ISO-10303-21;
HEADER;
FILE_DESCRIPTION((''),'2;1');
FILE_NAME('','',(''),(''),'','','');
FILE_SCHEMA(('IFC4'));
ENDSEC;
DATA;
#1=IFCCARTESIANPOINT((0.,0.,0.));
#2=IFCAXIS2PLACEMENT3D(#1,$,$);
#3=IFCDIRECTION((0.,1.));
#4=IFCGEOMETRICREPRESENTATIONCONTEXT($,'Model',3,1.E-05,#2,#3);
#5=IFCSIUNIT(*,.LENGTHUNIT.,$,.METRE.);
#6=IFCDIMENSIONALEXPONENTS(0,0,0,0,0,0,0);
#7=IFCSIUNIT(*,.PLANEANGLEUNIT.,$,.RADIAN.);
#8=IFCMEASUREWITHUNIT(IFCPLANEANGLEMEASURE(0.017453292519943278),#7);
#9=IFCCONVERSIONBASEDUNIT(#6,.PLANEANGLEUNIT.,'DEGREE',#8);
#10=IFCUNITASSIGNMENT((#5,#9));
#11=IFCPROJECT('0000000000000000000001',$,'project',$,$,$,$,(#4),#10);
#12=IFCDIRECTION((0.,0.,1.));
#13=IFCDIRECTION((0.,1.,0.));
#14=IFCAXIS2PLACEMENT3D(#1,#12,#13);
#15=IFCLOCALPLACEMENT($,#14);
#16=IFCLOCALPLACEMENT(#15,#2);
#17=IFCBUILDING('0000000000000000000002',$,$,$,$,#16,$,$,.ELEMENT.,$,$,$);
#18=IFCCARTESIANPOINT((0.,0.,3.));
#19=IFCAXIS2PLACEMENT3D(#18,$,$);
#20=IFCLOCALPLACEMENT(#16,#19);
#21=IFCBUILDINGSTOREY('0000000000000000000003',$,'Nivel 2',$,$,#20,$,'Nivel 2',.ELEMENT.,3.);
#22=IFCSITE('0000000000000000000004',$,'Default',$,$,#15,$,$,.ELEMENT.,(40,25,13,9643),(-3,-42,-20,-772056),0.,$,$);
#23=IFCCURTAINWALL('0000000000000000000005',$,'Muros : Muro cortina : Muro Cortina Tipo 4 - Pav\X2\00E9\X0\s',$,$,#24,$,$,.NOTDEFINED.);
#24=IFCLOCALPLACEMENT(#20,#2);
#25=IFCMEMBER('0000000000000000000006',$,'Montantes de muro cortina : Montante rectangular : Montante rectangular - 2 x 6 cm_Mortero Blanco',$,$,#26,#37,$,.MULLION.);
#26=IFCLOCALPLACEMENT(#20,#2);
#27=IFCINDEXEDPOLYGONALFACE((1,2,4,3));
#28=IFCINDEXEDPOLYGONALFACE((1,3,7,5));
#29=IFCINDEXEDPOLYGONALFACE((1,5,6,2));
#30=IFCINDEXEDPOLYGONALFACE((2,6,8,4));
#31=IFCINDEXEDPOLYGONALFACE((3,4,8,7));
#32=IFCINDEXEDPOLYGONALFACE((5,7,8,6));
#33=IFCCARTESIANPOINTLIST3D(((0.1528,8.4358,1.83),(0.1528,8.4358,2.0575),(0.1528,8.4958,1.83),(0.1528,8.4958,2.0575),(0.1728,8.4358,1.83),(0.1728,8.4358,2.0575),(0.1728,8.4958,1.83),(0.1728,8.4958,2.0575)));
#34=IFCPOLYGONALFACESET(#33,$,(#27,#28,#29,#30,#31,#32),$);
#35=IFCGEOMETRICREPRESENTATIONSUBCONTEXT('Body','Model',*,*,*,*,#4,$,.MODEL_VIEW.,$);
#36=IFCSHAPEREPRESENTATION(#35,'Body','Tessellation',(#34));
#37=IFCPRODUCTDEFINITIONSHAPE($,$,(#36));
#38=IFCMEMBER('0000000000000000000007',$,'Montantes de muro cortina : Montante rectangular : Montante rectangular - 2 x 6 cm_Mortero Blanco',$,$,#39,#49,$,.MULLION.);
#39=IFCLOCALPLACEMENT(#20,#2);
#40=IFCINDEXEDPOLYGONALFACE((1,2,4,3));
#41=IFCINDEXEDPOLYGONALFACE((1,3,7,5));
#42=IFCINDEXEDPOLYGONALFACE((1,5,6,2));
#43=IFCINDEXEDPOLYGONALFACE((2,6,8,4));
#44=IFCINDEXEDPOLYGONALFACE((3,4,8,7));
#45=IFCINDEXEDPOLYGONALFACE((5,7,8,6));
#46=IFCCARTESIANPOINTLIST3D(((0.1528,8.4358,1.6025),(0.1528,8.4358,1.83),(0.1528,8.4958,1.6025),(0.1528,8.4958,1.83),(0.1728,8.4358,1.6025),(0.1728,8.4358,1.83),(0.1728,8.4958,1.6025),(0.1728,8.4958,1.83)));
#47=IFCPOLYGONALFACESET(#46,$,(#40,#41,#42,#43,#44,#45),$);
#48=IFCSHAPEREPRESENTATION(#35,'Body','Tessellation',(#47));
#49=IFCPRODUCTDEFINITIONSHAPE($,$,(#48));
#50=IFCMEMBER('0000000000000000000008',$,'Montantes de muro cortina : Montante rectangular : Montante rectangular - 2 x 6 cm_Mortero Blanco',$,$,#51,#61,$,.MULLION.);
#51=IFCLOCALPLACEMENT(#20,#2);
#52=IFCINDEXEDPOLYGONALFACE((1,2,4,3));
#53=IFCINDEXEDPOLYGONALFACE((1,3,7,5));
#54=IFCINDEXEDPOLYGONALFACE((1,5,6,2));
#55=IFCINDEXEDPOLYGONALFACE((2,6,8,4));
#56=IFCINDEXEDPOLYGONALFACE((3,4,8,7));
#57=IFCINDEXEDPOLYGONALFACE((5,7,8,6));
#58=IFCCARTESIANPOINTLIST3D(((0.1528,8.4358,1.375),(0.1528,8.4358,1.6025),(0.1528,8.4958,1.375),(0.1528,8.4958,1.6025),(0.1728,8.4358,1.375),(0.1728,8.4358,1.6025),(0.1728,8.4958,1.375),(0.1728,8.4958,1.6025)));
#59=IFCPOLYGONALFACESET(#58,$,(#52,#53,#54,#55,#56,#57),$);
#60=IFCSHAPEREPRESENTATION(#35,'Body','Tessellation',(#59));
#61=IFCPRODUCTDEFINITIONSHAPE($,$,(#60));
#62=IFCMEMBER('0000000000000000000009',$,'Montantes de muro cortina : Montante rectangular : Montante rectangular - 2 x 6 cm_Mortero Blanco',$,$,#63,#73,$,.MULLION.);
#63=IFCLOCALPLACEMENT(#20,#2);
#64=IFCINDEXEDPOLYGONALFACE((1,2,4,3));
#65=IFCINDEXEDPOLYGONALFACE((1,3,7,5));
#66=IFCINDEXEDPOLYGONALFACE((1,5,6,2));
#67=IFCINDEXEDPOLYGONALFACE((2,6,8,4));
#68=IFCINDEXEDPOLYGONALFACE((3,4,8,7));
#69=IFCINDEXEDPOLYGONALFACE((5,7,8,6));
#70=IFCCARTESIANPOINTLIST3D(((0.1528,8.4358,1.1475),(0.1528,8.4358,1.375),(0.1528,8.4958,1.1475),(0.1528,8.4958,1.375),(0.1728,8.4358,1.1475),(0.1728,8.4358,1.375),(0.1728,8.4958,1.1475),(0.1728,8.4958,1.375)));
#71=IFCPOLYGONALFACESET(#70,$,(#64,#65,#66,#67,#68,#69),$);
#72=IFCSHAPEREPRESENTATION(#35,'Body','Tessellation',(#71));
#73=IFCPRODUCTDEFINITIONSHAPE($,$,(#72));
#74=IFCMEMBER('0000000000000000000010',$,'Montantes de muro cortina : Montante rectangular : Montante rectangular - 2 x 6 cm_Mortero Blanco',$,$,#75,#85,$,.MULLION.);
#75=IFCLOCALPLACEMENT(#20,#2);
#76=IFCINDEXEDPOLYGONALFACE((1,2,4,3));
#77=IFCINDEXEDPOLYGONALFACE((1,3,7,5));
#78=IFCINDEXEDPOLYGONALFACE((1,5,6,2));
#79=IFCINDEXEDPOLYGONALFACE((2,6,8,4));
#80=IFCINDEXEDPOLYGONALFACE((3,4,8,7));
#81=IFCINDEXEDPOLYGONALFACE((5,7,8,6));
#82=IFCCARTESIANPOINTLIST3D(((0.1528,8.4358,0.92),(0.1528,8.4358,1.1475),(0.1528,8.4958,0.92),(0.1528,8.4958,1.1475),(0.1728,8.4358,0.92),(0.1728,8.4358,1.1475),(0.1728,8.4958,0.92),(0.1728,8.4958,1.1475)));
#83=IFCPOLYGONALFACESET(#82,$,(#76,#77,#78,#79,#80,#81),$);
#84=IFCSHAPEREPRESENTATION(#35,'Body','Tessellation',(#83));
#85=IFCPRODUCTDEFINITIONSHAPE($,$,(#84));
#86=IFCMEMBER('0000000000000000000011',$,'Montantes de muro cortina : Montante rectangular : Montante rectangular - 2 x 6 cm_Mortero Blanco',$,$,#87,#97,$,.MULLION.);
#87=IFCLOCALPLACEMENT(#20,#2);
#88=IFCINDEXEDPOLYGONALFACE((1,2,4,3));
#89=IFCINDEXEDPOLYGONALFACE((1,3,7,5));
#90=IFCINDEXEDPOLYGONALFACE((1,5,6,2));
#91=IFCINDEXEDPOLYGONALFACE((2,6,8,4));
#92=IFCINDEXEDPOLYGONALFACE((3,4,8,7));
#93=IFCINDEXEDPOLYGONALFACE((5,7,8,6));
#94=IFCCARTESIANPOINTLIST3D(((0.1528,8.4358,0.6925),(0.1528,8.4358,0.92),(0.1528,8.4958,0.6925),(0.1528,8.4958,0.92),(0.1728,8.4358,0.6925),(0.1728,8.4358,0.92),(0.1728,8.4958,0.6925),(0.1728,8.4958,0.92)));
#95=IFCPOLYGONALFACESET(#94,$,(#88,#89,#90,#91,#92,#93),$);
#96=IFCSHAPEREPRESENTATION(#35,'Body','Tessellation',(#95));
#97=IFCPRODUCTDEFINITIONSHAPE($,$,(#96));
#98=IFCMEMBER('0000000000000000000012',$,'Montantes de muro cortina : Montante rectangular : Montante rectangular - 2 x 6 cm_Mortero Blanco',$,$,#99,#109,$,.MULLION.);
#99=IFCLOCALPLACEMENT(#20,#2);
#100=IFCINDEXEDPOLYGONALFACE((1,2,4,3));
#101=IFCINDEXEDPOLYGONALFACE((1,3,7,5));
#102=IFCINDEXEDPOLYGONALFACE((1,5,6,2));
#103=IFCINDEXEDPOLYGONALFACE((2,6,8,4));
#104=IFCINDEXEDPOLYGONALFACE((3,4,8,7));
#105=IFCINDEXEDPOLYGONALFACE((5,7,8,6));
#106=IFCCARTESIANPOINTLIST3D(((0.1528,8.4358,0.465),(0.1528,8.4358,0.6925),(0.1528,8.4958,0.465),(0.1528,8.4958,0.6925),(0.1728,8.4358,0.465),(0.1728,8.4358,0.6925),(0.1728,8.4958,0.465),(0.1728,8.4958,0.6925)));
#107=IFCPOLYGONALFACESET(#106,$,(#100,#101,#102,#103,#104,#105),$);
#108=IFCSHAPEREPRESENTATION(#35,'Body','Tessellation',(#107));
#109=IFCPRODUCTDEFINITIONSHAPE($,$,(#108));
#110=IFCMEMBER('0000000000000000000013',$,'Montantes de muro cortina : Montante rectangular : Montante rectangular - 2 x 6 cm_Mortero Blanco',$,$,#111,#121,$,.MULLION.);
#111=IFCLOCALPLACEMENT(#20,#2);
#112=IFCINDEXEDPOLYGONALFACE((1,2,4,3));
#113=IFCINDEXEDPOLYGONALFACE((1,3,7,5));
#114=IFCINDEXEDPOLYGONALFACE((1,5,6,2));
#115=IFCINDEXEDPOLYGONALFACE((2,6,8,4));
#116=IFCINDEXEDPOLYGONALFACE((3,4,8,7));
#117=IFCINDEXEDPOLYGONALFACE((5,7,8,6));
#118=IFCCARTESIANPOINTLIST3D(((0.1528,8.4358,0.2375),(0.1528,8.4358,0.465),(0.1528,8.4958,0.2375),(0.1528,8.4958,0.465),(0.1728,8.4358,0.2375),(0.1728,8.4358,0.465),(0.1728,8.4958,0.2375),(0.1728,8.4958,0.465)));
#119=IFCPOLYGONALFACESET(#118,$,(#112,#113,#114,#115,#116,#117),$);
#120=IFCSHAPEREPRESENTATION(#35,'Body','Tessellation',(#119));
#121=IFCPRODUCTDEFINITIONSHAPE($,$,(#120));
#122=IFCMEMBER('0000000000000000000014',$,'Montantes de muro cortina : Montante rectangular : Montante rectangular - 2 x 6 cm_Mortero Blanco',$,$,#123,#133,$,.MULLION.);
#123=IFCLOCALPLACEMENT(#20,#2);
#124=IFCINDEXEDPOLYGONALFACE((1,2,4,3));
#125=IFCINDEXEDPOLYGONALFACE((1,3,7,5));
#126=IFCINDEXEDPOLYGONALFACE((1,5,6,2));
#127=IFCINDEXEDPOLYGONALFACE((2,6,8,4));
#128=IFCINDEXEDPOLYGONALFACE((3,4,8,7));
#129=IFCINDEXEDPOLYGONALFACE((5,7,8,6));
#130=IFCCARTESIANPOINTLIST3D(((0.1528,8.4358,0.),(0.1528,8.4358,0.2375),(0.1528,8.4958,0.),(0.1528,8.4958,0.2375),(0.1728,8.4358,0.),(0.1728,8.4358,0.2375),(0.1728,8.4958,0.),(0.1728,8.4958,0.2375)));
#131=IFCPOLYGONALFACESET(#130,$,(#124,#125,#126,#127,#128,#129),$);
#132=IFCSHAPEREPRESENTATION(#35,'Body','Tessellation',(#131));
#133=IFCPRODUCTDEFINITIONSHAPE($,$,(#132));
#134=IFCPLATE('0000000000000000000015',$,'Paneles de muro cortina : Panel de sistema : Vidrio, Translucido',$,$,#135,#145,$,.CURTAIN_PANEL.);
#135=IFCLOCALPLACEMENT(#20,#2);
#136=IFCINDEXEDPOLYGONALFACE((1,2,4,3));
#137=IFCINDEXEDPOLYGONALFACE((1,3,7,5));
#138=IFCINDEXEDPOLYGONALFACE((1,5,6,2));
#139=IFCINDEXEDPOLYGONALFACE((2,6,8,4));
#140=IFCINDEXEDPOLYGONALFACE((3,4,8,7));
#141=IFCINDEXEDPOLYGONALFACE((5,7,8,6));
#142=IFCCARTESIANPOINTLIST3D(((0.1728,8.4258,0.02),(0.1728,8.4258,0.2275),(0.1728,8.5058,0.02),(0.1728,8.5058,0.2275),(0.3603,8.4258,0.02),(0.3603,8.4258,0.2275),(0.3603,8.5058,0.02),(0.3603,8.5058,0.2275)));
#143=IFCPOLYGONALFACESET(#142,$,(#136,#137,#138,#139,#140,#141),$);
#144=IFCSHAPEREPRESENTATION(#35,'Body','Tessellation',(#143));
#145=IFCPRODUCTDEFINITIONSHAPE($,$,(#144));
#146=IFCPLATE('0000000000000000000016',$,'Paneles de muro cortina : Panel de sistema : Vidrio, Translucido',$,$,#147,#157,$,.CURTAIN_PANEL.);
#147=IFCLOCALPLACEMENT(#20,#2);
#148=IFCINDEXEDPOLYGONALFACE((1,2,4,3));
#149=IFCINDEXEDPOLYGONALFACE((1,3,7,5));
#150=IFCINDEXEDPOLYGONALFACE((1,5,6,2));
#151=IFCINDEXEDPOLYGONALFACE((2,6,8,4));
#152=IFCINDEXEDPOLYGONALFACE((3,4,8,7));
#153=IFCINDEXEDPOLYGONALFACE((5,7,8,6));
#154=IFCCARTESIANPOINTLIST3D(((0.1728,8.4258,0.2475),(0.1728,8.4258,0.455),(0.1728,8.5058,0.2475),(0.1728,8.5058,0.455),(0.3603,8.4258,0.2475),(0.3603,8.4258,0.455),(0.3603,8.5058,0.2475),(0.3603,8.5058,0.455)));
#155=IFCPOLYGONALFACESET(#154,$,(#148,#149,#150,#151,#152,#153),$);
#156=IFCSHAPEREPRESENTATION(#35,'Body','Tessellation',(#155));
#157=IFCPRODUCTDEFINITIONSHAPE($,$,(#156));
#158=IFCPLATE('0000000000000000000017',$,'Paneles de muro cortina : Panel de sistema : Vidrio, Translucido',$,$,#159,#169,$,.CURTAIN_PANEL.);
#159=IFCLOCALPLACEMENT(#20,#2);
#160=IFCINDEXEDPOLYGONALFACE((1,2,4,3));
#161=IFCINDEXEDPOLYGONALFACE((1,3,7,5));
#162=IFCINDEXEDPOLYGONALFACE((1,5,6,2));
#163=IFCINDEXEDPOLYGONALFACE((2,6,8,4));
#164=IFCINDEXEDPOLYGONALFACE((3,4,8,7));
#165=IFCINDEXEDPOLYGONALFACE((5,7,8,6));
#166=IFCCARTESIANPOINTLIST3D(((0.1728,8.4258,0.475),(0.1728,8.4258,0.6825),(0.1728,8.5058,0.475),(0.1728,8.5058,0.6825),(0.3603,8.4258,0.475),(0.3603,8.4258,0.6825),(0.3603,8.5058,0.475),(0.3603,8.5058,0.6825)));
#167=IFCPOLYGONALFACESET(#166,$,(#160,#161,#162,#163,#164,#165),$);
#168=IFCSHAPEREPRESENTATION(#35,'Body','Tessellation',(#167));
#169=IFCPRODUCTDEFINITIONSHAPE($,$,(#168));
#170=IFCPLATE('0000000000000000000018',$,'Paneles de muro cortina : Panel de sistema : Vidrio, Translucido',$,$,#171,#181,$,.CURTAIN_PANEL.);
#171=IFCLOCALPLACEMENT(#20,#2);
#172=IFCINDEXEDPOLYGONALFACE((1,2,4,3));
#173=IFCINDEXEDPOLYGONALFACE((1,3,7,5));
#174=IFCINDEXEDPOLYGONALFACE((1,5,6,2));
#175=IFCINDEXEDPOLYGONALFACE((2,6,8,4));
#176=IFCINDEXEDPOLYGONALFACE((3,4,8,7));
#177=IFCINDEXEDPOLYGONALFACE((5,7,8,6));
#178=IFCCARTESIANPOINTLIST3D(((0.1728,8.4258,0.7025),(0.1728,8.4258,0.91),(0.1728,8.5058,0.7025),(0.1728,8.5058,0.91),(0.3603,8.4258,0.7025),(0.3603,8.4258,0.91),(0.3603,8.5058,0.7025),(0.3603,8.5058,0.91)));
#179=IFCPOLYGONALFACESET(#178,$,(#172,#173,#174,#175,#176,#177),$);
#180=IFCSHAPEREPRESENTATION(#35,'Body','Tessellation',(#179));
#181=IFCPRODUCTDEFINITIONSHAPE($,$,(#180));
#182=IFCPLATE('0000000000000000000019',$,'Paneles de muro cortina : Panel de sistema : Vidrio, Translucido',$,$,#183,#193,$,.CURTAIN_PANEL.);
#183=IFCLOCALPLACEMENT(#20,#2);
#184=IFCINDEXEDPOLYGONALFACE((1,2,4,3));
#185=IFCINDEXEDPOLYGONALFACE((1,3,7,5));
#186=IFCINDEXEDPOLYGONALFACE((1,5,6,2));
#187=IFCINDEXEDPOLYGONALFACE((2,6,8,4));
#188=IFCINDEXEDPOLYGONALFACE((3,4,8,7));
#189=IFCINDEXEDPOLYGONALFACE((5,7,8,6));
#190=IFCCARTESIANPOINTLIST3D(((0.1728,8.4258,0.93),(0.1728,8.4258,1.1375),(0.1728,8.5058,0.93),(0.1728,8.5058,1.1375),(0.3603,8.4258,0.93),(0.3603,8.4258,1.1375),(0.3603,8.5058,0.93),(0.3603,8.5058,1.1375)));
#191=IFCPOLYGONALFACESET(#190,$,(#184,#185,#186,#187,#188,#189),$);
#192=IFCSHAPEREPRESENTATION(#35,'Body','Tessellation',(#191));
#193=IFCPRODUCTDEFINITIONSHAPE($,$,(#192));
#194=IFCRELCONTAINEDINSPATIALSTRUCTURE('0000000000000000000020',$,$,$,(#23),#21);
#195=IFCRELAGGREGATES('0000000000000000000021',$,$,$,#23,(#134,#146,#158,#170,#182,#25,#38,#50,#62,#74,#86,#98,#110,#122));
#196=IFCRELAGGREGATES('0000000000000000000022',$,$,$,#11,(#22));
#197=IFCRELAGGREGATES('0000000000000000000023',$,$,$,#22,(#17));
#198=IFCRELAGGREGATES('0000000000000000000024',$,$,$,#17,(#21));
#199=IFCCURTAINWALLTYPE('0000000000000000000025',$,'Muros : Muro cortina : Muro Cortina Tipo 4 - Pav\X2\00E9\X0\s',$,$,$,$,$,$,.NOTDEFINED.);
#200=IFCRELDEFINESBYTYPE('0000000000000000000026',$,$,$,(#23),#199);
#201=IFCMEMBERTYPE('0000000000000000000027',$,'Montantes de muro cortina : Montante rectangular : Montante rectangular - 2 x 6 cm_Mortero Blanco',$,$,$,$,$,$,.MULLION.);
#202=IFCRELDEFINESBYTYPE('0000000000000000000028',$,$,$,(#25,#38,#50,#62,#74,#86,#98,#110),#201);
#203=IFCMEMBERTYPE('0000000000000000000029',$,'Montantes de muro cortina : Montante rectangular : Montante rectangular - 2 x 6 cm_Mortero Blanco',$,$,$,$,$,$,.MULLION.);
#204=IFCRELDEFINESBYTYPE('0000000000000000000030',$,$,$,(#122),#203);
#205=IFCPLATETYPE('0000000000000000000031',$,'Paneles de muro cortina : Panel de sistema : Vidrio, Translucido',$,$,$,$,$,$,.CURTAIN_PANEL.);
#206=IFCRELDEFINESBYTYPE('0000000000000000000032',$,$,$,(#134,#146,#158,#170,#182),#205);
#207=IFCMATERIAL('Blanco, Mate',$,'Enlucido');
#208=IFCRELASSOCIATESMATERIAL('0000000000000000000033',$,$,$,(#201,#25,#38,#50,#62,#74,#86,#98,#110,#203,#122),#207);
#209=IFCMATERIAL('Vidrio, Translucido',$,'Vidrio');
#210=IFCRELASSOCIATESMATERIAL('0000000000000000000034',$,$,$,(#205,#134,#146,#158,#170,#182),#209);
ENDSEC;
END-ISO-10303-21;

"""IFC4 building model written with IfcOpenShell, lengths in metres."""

from ifc_helpers import new_model, entity, si_unit, converted_unit, direction, frame, origin, place, context, subcontext, project, spatial, indexed_curve, outline, extrude, source, transform, mapped, material, type_object, type_shapes, element, aggregate, save


model = new_model("IFC4")

# Units and contexts
model_context = context("Model", 3, precision=1e-05, world=origin(), true_north=direction((0.0, 1.0)))
body_context = subcontext(model_context, "Body", "Model", "MODEL_VIEW")
ifc_project = project(units=[si_unit("LENGTHUNIT", "METRE"), converted_unit("PLANEANGLEUNIT", "DEGREE", entity("IfcPlaneAngleMeasure", 0.017453292519943278), si_unit("PLANEANGLEUNIT", "RADIAN"), dimensions=[0, 0, 0, 0, 0, 0, 0])], contexts=[model_context])

# Site, building, storey
site_placement = place(None, frame((0.0, 0.0, 0.0), z_axis=(0.0, 0.0, 1.0), x_axis=(0.0, 1.0, 0.0)))
site = spatial("IfcSite", under=ifc_project, at=site_placement, Name="Default", CompositionType="ELEMENT", RefLatitude=(40, 25, 13, 9643), RefLongitude=(-3, -42, -20, -772056), RefElevation=0.0)
building_placement = place(site_placement, origin())
building = spatial("IfcBuilding", under=site, at=building_placement, CompositionType="ELEMENT")
storey_placement = place(building_placement, frame((0.0, 0.0, 3.0)))
storey = spatial("IfcBuildingStorey", under=building, at=storey_placement, Name="Nivel 2", LongName="Nivel 2", CompositionType="ELEMENT", Elevation=3.0)

# Curtain wall, members, plates
curtain_wall_type = type_object("IfcCurtainWallType", Name="Muros : Muro cortina : Muro Cortina Tipo 4 - Pavés", PredefinedType="NOTDEFINED")
curtain_wall_placement = place(storey_placement, frame((0.0, 0.0, -3.0)))
curtain_wall = element("IfcCurtainWall", 1, at=curtain_wall_placement, inside=storey, type_object=curtain_wall_type, Name="Muros : Muro cortina : Muro Cortina Tipo 4 - Pavés", PredefinedType="NOTDEFINED")
ifc_material_1 = material(Name="Blanco, Mate", Category="Enlucido")
member_type_1 = type_object("IfcMemberType", Name="Montantes de muro cortina : Montante rectangular : Montante rectangular - 2 x 6 cm_Mortero Blanco", PredefinedType="MULLION", material=ifc_material_1)
shared_shape_1 = source(origin(), body_context, "Body", "SweptSolid", [
    extrude(outline(indexed_curve([(-0.01, -0.03), (0.01, -0.03), (0.01, 0.03), (-0.01, 0.03), (-0.01, -0.03)], self_intersect=False)), frame((-0.01, 0.0, -0.2275), z_axis=(0.0, 0.0, 1.0), x_axis=(-1.0, 0.0, 0.0)), (0.0, 0.0, 1.0), 0.2275),
])
type_shapes(member_type_1, [shared_shape_1])
member_1_placement = place(curtain_wall_placement, frame((0.1528, 8.4658, 4.83), z_axis=(0.0, 0.0, -1.0), x_axis=(-1.0, 0.0, 0.0)))
member_1 = element("IfcMember", 2, at=member_1_placement, type_object=member_type_1, material=ifc_material_1, Name="Montantes de muro cortina : Montante rectangular : Montante rectangular - 2 x 6 cm_Mortero Blanco", PredefinedType="MULLION", context=body_context, shape_type="MappedRepresentation", body=[
    mapped(shared_shape_1, transform((0.0, 0.0, 0.0), scale=1.0)),
])
member_2_placement = place(curtain_wall_placement, frame((0.1528, 8.4658, 4.6025), z_axis=(0.0, 0.0, -1.0), x_axis=(-1.0, 0.0, 0.0)))
member_2 = element("IfcMember", 3, at=member_2_placement, type_object=member_type_1, material=ifc_material_1, Name="Montantes de muro cortina : Montante rectangular : Montante rectangular - 2 x 6 cm_Mortero Blanco", PredefinedType="MULLION", context=body_context, shape_type="MappedRepresentation", body=[
    mapped(shared_shape_1, transform((0.0, 0.0, 0.0), scale=1.0)),
])
member_3_placement = place(curtain_wall_placement, frame((0.1528, 8.4658, 4.375), z_axis=(0.0, 0.0, -1.0), x_axis=(-1.0, 0.0, 0.0)))
member_3 = element("IfcMember", 4, at=member_3_placement, type_object=member_type_1, material=ifc_material_1, Name="Montantes de muro cortina : Montante rectangular : Montante rectangular - 2 x 6 cm_Mortero Blanco", PredefinedType="MULLION", context=body_context, shape_type="MappedRepresentation", body=[
    mapped(shared_shape_1, transform((0.0, 0.0, 0.0), scale=1.0)),
])
member_4_placement = place(curtain_wall_placement, frame((0.1528, 8.4658, 4.1475), z_axis=(0.0, 0.0, -1.0), x_axis=(-1.0, 0.0, 0.0)))
member_4 = element("IfcMember", 5, at=member_4_placement, type_object=member_type_1, material=ifc_material_1, Name="Montantes de muro cortina : Montante rectangular : Montante rectangular - 2 x 6 cm_Mortero Blanco", PredefinedType="MULLION", context=body_context, shape_type="MappedRepresentation", body=[
    mapped(shared_shape_1, transform((0.0, 0.0, 0.0), scale=1.0)),
])
member_5_placement = place(curtain_wall_placement, frame((0.1528, 8.4658, 3.92), z_axis=(0.0, 0.0, -1.0), x_axis=(-1.0, 0.0, 0.0)))
member_5 = element("IfcMember", 6, at=member_5_placement, type_object=member_type_1, material=ifc_material_1, Name="Montantes de muro cortina : Montante rectangular : Montante rectangular - 2 x 6 cm_Mortero Blanco", PredefinedType="MULLION", context=body_context, shape_type="MappedRepresentation", body=[
    mapped(shared_shape_1, transform((0.0, 0.0, 0.0), scale=1.0)),
])
member_6_placement = place(curtain_wall_placement, frame((0.1528, 8.4658, 3.6925), z_axis=(0.0, 0.0, -1.0), x_axis=(-1.0, 0.0, 0.0)))
member_6 = element("IfcMember", 7, at=member_6_placement, type_object=member_type_1, material=ifc_material_1, Name="Montantes de muro cortina : Montante rectangular : Montante rectangular - 2 x 6 cm_Mortero Blanco", PredefinedType="MULLION", context=body_context, shape_type="MappedRepresentation", body=[
    mapped(shared_shape_1, transform((0.0, 0.0, 0.0), scale=1.0)),
])
member_7_placement = place(curtain_wall_placement, frame((0.1528, 8.4658, 3.465), z_axis=(0.0, 0.0, -1.0), x_axis=(-1.0, 0.0, 0.0)))
member_7 = element("IfcMember", 8, at=member_7_placement, type_object=member_type_1, material=ifc_material_1, Name="Montantes de muro cortina : Montante rectangular : Montante rectangular - 2 x 6 cm_Mortero Blanco", PredefinedType="MULLION", context=body_context, shape_type="MappedRepresentation", body=[
    mapped(shared_shape_1, transform((0.0, 0.0, 0.0), scale=1.0)),
])
member_8_placement = place(curtain_wall_placement, frame((0.1528, 8.4658, 3.2375), z_axis=(0.0, 0.0, -1.0), x_axis=(-1.0, 0.0, 0.0)))
member_8 = element("IfcMember", 9, at=member_8_placement, type_object=member_type_1, material=ifc_material_1, Name="Montantes de muro cortina : Montante rectangular : Montante rectangular - 2 x 6 cm_Mortero Blanco", PredefinedType="MULLION", context=body_context, shape_type="MappedRepresentation", body=[
    mapped(shared_shape_1, transform((0.0, 0.0, 0.0), scale=1.0)),
])
member_type_2 = type_object("IfcMemberType", Name="Montantes de muro cortina : Montante rectangular : Montante rectangular - 2 x 6 cm_Mortero Blanco", PredefinedType="MULLION", material=ifc_material_1)
shared_shape_2 = source(origin(), body_context, "Body", "SweptSolid", [
    extrude(outline(indexed_curve([(-0.01, -0.03), (0.01, -0.03), (0.01, 0.03), (-0.01, 0.03), (-0.01, -0.03)], self_intersect=False)), frame((-0.01, 0.0, -0.2375), z_axis=(0.0, 0.0, 1.0), x_axis=(-1.0, 0.0, 0.0)), (0.0, 0.0, 1.0), 0.2375),
])
type_shapes(member_type_2, [shared_shape_2])
member_9_placement = place(curtain_wall_placement, frame((0.1528, 8.4658, 3.0), z_axis=(0.0, 0.0, -1.0), x_axis=(-1.0, 0.0, 0.0)))
member_9 = element("IfcMember", 10, at=member_9_placement, type_object=member_type_2, material=ifc_material_1, Name="Montantes de muro cortina : Montante rectangular : Montante rectangular - 2 x 6 cm_Mortero Blanco", PredefinedType="MULLION", context=body_context, shape_type="MappedRepresentation", body=[
    mapped(shared_shape_2, transform((0.0, 0.0, 0.0), scale=1.0)),
])
ifc_material_2 = material(Name="Vidrio, Translucido", Category="Vidrio")
plate_type = type_object("IfcPlateType", Name="Paneles de muro cortina : Panel de sistema : Vidrio, Translucido", PredefinedType="CURTAIN_PANEL", material=ifc_material_2)
shared_shape_3 = source(origin(), body_context, "Body", "SweptSolid", [
    extrude(outline(indexed_curve([(-0.04, -0.0938), (0.04, -0.0938), (0.04, 0.0938), (-0.04, 0.0938), (-0.04, -0.0938)], self_intersect=False)), frame((0.0, 0.0, 0.0), z_axis=(0.0, 0.0, 1.0), x_axis=(0.0, 1.0, 0.0)), (0.0, 0.0, 1.0), 0.2075),
])
type_shapes(plate_type, [shared_shape_3])
plate_1_placement = place(curtain_wall_placement, frame((0.2665, 8.4658, 3.02), z_axis=(0.0, 0.0, 1.0), x_axis=(-1.0, 0.0, 0.0)))
plate_1 = element("IfcPlate", 11, at=plate_1_placement, type_object=plate_type, material=ifc_material_2, Name="Paneles de muro cortina : Panel de sistema : Vidrio, Translucido", PredefinedType="CURTAIN_PANEL", context=body_context, shape_type="MappedRepresentation", body=[
    mapped(shared_shape_3, transform((0.0, 0.0, 0.0), scale=1.0)),
])
plate_2_placement = place(curtain_wall_placement, frame((0.2665, 8.4658, 3.2475), z_axis=(0.0, 0.0, 1.0), x_axis=(-1.0, 0.0, 0.0)))
plate_2 = element("IfcPlate", 12, at=plate_2_placement, type_object=plate_type, material=ifc_material_2, Name="Paneles de muro cortina : Panel de sistema : Vidrio, Translucido", PredefinedType="CURTAIN_PANEL", context=body_context, shape_type="MappedRepresentation", body=[
    mapped(shared_shape_3, transform((0.0, 0.0, 0.0), scale=1.0)),
])
plate_3_placement = place(curtain_wall_placement, frame((0.2665, 8.4658, 3.475), z_axis=(0.0, 0.0, 1.0), x_axis=(-1.0, 0.0, 0.0)))
plate_3 = element("IfcPlate", 13, at=plate_3_placement, type_object=plate_type, material=ifc_material_2, Name="Paneles de muro cortina : Panel de sistema : Vidrio, Translucido", PredefinedType="CURTAIN_PANEL", context=body_context, shape_type="MappedRepresentation", body=[
    mapped(shared_shape_3, transform((0.0, 0.0, 0.0), scale=1.0)),
])
plate_4_placement = place(curtain_wall_placement, frame((0.2665, 8.4658, 3.7025), z_axis=(0.0, 0.0, 1.0), x_axis=(-1.0, 0.0, 0.0)))
plate_4 = element("IfcPlate", 14, at=plate_4_placement, type_object=plate_type, material=ifc_material_2, Name="Paneles de muro cortina : Panel de sistema : Vidrio, Translucido", PredefinedType="CURTAIN_PANEL", context=body_context, shape_type="MappedRepresentation", body=[
    mapped(shared_shape_3, transform((0.0, 0.0, 0.0), scale=1.0)),
])
plate_5_placement = place(curtain_wall_placement, frame((0.2665, 8.4658, 3.93), z_axis=(0.0, 0.0, 1.0), x_axis=(-1.0, 0.0, 0.0)))
plate_5 = element("IfcPlate", 15, at=plate_5_placement, type_object=plate_type, material=ifc_material_2, Name="Paneles de muro cortina : Panel de sistema : Vidrio, Translucido", PredefinedType="CURTAIN_PANEL", context=body_context, shape_type="MappedRepresentation", body=[
    mapped(shared_shape_3, transform((0.0, 0.0, 0.0), scale=1.0)),
])
aggregate(curtain_wall, [plate_1, plate_2, plate_3, plate_4, plate_5, member_1, member_2, member_3, member_4, member_5, member_6, member_7, member_8, member_9])

save(model, "model.ifc")
